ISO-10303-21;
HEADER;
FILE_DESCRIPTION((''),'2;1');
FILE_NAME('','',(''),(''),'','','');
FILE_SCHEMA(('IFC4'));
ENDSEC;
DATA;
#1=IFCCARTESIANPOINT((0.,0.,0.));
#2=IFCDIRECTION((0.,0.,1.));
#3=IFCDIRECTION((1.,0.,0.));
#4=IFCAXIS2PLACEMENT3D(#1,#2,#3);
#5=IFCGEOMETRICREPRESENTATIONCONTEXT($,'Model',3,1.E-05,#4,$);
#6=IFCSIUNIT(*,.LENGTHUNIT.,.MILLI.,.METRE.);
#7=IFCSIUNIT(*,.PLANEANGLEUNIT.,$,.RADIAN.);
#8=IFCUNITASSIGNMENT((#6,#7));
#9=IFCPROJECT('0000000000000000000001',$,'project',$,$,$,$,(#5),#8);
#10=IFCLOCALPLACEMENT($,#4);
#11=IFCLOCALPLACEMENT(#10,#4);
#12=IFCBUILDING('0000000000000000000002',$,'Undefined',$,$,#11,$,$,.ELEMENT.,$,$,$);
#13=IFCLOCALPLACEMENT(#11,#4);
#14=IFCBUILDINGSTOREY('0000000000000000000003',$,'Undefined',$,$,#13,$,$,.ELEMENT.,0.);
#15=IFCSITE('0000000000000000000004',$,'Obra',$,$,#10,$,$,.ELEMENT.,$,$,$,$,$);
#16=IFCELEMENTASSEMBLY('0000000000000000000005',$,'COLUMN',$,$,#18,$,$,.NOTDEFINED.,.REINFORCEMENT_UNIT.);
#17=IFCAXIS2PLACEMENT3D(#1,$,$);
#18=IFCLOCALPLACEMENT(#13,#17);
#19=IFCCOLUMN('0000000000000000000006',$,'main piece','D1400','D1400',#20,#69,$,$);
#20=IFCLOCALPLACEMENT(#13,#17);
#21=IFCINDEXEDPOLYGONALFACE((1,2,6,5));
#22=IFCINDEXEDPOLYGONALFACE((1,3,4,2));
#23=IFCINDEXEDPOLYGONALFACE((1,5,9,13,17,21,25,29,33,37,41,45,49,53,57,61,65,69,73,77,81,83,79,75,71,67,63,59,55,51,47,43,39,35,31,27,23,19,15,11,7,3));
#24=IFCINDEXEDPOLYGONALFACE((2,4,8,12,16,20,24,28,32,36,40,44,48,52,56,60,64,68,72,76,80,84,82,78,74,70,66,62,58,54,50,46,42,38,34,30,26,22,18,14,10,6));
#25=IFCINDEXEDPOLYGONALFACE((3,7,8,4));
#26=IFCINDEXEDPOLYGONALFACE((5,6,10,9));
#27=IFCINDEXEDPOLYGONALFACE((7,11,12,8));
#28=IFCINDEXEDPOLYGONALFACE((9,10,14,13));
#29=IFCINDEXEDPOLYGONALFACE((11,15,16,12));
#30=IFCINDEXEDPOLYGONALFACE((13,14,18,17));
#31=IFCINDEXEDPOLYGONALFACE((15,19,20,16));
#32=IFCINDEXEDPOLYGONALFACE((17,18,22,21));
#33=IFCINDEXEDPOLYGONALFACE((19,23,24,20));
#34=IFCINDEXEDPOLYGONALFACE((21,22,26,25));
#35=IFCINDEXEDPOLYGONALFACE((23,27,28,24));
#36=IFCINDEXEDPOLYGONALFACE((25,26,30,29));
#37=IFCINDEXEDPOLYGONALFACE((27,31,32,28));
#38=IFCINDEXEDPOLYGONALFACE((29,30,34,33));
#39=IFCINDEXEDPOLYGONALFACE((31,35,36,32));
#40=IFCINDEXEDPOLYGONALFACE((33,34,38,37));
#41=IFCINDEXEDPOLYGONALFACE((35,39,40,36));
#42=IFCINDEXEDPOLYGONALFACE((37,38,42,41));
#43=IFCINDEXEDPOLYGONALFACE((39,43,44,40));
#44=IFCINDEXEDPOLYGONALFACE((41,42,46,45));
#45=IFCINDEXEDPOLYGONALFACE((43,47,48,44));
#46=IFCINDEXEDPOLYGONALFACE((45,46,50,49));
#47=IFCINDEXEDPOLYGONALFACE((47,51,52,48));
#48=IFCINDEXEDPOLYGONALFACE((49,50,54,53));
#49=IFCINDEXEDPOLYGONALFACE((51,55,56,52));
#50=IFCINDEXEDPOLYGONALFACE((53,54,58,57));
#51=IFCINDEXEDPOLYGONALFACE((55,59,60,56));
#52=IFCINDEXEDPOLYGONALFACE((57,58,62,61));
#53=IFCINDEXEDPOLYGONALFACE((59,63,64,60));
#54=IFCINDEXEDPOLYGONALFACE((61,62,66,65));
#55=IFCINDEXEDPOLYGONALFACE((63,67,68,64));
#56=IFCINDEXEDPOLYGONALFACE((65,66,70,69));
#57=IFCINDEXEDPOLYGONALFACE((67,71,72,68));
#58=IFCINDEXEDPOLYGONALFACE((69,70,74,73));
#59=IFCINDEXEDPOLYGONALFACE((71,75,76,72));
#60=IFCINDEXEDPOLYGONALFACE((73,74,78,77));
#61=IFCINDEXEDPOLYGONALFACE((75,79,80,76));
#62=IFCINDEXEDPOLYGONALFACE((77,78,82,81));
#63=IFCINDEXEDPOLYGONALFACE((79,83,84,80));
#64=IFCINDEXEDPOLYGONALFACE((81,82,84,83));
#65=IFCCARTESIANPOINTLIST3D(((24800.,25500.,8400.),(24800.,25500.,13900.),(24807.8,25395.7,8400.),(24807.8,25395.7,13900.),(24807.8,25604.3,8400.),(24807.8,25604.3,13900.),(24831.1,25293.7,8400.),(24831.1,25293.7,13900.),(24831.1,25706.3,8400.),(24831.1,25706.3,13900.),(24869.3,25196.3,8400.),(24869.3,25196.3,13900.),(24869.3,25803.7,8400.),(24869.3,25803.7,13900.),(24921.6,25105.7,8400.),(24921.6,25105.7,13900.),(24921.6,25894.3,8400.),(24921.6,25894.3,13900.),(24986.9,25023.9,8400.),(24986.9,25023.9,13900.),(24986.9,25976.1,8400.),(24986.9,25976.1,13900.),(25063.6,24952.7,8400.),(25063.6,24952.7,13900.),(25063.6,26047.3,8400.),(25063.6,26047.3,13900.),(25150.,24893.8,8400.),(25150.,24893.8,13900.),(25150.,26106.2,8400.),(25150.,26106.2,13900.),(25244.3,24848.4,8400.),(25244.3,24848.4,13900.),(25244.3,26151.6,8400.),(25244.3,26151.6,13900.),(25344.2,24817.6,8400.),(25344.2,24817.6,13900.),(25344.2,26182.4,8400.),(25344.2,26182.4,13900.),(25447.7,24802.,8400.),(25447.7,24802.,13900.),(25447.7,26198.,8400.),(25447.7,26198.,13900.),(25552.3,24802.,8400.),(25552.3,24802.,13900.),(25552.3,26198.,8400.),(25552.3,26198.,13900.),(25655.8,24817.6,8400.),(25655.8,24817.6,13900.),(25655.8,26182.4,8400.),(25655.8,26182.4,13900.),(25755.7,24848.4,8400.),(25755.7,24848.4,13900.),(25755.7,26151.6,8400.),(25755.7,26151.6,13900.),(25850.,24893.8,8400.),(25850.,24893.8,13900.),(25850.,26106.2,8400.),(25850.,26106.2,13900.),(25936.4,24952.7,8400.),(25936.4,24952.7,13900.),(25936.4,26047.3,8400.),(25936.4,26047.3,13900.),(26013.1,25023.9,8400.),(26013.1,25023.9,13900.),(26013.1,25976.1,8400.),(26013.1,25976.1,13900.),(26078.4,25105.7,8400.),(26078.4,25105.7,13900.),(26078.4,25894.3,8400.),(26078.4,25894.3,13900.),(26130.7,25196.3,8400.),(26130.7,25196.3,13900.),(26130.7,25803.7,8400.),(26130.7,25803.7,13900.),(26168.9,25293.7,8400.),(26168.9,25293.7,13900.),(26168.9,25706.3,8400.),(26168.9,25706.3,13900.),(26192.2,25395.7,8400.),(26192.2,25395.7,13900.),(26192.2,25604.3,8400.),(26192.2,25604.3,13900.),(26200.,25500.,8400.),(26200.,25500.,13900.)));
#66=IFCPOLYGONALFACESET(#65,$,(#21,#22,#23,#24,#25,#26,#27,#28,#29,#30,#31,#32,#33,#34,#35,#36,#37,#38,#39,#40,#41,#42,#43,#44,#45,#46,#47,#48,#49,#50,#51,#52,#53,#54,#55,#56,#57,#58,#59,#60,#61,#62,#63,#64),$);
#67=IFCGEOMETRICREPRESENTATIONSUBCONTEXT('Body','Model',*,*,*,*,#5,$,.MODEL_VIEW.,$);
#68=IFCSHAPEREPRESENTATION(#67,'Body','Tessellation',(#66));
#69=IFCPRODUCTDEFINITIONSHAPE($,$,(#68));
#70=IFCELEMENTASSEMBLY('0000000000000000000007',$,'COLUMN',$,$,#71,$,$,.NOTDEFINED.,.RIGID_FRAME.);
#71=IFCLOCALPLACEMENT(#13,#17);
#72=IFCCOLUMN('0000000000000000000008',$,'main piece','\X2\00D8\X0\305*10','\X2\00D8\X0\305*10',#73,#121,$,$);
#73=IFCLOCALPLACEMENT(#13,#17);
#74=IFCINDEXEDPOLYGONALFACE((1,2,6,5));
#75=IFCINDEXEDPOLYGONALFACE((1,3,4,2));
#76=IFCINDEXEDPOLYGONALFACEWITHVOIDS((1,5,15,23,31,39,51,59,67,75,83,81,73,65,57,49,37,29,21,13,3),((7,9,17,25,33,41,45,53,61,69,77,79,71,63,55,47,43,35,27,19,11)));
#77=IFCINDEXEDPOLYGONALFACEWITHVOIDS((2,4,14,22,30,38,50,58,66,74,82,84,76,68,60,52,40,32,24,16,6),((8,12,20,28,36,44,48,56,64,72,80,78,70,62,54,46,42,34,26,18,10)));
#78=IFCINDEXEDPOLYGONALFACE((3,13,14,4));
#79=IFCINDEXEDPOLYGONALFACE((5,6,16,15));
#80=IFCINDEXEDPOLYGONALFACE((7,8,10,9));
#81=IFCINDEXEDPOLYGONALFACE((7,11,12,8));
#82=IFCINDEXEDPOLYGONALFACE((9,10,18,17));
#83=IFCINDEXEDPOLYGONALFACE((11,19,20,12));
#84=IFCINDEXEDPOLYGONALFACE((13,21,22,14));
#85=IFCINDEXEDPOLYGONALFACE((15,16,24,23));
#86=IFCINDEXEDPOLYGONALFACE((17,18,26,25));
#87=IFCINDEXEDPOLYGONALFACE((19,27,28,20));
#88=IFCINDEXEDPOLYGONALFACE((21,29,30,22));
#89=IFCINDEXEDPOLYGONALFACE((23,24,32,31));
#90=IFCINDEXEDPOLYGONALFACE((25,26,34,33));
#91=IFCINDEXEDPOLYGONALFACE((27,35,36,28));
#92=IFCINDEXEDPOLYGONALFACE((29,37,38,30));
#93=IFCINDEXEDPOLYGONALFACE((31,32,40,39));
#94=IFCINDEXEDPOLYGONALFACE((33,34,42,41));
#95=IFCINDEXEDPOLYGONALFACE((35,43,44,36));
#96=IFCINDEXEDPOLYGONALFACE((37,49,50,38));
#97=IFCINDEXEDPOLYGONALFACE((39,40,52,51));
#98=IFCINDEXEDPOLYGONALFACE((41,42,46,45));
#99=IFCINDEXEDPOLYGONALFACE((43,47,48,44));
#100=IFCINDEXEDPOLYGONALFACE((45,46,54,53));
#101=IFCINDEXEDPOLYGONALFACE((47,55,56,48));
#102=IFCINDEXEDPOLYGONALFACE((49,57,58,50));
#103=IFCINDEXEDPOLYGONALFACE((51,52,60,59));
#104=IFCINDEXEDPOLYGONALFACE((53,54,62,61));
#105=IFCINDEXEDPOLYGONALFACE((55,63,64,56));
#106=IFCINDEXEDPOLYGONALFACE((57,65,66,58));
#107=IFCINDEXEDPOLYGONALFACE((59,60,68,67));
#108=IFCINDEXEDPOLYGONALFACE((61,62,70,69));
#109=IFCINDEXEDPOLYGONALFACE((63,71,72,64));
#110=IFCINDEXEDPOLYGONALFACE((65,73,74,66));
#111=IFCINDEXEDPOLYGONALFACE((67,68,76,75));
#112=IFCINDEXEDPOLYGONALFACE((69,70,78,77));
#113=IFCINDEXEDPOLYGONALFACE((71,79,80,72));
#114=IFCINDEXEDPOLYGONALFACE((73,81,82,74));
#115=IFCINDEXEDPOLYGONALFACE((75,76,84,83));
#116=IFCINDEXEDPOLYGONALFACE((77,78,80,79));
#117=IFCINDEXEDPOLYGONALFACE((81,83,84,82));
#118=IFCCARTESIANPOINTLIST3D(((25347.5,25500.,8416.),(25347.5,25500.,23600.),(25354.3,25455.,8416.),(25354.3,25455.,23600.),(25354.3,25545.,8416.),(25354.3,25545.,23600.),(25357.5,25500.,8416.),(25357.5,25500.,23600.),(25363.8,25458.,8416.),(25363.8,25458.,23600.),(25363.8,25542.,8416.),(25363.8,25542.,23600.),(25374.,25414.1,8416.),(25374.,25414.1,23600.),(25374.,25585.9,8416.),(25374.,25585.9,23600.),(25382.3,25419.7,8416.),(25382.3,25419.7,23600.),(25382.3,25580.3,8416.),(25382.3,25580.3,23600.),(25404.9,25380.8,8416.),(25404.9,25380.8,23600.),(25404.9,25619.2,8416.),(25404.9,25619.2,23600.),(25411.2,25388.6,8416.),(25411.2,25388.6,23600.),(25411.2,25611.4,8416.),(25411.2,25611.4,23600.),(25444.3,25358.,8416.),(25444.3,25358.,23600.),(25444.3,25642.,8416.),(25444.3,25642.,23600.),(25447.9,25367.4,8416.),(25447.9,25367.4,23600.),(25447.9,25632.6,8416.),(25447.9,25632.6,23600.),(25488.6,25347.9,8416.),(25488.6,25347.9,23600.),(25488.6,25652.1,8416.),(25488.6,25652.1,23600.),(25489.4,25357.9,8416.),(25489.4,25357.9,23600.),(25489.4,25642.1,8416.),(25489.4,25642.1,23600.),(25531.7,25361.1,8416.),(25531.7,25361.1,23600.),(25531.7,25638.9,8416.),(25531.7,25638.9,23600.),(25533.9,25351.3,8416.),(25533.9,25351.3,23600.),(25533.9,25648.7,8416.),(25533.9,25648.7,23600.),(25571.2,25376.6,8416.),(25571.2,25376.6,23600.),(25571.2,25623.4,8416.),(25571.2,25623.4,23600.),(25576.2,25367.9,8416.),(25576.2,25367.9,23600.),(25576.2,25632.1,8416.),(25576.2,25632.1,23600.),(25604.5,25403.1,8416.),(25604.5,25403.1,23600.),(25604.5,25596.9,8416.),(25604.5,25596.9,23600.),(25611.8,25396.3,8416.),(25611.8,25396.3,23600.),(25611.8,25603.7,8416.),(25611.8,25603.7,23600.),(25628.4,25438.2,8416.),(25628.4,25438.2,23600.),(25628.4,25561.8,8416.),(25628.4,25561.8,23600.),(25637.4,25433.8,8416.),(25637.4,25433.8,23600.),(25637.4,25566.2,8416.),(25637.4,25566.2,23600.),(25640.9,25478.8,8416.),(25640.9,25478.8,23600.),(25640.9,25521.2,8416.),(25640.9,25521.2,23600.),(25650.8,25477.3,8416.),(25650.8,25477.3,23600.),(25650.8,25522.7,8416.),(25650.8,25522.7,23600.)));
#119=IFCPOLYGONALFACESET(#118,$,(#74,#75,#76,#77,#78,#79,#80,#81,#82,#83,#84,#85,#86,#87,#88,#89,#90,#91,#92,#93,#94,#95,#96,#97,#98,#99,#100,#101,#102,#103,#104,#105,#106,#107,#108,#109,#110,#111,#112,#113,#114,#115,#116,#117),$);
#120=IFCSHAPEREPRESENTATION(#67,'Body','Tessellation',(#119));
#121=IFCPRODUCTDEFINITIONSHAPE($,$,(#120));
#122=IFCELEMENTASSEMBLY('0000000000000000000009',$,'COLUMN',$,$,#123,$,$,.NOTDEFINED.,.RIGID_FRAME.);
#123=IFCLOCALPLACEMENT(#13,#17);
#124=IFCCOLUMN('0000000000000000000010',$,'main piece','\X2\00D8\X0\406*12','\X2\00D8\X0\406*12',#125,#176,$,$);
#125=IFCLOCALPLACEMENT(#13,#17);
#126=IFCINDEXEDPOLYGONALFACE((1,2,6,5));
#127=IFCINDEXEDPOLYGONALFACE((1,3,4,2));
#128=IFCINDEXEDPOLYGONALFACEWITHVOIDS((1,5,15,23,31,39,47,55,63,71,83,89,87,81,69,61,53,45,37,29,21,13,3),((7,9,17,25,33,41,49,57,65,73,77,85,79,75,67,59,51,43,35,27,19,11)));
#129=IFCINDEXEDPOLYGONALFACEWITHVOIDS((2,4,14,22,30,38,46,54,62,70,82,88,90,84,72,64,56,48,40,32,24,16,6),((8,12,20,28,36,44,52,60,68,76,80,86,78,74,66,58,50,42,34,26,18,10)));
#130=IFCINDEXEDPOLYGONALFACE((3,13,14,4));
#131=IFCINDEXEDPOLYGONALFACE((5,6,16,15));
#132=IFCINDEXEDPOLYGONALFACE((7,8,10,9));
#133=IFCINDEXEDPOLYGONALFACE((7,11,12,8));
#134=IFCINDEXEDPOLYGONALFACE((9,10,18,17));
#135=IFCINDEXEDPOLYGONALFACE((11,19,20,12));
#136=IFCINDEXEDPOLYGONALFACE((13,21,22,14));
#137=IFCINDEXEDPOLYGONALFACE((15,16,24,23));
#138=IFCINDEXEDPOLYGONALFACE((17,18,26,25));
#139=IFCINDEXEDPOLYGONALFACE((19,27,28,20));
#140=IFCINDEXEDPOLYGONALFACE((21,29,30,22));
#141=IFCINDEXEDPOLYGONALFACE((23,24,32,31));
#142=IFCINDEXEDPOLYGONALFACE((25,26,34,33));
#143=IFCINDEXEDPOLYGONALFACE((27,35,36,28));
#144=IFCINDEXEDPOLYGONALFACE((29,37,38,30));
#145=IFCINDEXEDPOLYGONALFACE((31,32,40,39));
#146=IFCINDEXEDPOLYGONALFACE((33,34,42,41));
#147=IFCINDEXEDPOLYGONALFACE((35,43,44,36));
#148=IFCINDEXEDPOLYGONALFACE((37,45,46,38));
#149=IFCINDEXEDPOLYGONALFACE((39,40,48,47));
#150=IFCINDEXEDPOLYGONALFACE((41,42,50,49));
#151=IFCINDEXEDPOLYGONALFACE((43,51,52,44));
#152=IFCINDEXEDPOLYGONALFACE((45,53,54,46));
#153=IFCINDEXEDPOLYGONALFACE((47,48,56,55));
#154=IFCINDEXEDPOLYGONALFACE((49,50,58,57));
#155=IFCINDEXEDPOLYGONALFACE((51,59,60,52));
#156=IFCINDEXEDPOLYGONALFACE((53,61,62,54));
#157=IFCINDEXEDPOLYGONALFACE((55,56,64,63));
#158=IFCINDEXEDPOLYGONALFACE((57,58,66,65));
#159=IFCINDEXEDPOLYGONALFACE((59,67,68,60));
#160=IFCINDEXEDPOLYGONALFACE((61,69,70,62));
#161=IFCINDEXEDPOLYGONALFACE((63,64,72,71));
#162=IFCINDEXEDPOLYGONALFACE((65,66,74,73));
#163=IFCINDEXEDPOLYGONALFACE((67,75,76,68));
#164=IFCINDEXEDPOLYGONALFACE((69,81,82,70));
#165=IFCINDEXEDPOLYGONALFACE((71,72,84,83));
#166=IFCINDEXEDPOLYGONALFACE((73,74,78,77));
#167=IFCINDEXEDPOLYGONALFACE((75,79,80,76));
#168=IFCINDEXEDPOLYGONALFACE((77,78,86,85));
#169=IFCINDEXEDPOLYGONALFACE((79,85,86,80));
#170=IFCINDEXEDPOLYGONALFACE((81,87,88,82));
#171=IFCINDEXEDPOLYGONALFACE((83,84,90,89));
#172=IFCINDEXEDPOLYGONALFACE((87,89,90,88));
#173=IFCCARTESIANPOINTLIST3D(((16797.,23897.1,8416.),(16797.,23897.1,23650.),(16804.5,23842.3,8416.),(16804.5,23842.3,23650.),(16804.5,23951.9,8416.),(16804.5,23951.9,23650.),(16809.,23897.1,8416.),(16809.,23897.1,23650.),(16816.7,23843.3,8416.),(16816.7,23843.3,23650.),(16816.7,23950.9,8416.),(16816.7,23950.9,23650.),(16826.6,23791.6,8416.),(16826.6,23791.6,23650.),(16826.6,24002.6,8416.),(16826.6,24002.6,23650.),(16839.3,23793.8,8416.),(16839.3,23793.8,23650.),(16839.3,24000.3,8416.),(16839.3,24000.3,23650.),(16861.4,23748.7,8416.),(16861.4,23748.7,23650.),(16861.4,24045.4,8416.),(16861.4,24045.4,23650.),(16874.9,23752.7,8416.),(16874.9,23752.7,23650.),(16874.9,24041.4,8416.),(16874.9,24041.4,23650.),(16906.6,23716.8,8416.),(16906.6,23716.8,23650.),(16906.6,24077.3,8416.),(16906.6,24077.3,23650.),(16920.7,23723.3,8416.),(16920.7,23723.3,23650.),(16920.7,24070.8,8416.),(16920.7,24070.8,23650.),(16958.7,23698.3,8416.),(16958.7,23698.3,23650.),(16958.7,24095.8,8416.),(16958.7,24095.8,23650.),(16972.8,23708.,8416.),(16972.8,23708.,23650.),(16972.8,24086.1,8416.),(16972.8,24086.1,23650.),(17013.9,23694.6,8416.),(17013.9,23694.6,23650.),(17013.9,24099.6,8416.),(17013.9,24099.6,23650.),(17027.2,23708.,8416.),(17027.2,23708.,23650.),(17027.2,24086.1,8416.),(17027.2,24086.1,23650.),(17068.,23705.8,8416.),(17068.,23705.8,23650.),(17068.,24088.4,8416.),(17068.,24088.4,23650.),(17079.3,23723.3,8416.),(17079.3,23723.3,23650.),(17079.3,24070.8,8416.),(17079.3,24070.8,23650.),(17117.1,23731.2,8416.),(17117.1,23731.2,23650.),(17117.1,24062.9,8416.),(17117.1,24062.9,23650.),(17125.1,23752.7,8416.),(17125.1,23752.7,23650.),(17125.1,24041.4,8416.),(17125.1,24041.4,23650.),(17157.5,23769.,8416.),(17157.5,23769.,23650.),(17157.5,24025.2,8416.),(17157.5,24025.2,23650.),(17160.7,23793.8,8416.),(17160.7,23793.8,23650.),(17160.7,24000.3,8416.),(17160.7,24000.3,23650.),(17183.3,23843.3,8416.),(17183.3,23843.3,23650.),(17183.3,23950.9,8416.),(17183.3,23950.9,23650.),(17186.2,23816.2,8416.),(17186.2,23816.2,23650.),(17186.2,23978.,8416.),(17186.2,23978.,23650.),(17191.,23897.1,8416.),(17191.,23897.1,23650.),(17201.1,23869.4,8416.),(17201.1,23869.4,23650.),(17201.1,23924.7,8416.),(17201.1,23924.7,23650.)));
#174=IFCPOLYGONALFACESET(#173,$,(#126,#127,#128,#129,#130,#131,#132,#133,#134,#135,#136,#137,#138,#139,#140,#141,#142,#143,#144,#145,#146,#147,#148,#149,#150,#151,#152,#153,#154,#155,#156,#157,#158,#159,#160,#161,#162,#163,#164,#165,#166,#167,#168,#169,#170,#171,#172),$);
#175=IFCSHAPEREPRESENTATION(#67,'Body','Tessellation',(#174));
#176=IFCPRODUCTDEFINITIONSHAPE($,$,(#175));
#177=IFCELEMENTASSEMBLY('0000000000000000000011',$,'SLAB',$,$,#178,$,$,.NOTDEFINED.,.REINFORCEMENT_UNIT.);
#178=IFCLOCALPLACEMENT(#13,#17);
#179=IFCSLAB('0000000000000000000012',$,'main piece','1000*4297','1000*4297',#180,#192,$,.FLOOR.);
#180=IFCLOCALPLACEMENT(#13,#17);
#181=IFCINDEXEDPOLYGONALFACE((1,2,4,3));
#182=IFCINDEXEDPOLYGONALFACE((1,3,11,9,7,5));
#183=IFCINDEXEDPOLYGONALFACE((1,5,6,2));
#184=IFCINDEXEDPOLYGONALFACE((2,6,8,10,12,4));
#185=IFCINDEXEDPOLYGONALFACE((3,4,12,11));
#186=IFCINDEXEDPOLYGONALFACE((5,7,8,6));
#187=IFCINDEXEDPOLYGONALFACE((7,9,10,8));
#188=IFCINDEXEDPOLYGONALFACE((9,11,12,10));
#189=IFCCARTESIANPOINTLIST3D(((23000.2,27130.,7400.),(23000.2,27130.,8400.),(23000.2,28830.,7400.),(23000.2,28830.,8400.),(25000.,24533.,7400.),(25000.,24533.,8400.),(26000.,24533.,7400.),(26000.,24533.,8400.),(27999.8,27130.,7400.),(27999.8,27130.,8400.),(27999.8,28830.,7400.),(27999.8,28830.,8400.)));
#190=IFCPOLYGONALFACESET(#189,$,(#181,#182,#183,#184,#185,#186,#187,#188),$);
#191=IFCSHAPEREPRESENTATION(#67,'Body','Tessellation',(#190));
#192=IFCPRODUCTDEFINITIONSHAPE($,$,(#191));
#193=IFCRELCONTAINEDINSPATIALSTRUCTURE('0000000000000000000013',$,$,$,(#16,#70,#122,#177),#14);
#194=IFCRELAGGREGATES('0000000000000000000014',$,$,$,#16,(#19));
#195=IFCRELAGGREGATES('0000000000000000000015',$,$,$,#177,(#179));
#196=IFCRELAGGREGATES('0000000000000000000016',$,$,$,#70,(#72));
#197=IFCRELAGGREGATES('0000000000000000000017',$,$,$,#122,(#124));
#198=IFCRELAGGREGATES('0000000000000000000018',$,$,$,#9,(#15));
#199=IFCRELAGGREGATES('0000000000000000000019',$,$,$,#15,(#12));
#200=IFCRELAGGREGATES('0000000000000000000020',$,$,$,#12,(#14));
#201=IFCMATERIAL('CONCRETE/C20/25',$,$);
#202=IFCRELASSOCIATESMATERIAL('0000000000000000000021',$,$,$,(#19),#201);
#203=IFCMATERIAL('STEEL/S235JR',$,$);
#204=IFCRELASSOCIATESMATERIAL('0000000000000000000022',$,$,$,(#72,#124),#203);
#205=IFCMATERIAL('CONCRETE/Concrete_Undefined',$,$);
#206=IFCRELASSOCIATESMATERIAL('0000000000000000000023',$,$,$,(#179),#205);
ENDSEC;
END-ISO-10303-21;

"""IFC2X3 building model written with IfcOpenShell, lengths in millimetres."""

from ifc_helpers import new_model, si_unit, frame, origin_with_axes, origin_2d_with_axis, place, context, subcontext, project, spatial, polyline, circle, hollow_circle, outline, extrude, clip, halfspace, material, element, aggregate, save


model = new_model("IFC2X3")

# Units and contexts
model_context = context("Model", 3, precision=1e-05, world=origin_with_axes())
body_context = subcontext(model_context, "Body", "Model", "MODEL_VIEW")
ifc_project = project(units=[si_unit("LENGTHUNIT", "METRE", prefix="MILLI"), si_unit("PLANEANGLEUNIT", "RADIAN")], contexts=[model_context])

# Site, building, storey
site_placement = place(None, origin_with_axes())
site = spatial("IfcSite", under=ifc_project, at=site_placement, Name="Obra", CompositionType="ELEMENT")
building_placement = place(site_placement, origin_with_axes())
building = spatial("IfcBuilding", under=site, at=building_placement, Name="Undefined", CompositionType="ELEMENT")
storey_placement = place(building_placement, origin_with_axes())
storey = spatial("IfcBuildingStorey", under=building, at=storey_placement, Name="Undefined", CompositionType="ELEMENT", Elevation=0.0)

# Element assemblies, columns
assembly_1_placement = place(storey_placement, origin_with_axes())
assembly_1 = element("IfcElementAssembly", 1, at=assembly_1_placement, inside=storey, Name="COLUMN", AssemblyPlace="NOTDEFINED", PredefinedType="REINFORCEMENT_UNIT")
ifc_material_1 = material(Name="CONCRETE/C20/25")
column_1_placement = place(assembly_1_placement, frame((25500.0, 25500.0, 8400.0), z_axis=(0.0, 0.0, 1.0), x_axis=(0.0, 1.0, 0.0)))
column_1 = element("IfcColumn", 2, at=column_1_placement, material=ifc_material_1, Name="main piece", Description="D1400", ObjectType="D1400", context=body_context, shape_type="SweptSolid", body=[
    extrude(circle(Radius=700.0, at=origin_2d_with_axis()), frame((0.0, 0.0, 5500.0), z_axis=(0.0, 0.0, -1.0), x_axis=(0.0, 1.0, 0.0)), (0.0, 0.0, 1.0), 5500.0),
])
aggregate(assembly_1, [column_1])
assembly_2_placement = place(storey_placement, origin_with_axes())
assembly_2 = element("IfcElementAssembly", 3, at=assembly_2_placement, inside=storey, Name="COLUMN", AssemblyPlace="NOTDEFINED", PredefinedType="RIGID_FRAME")
ifc_material_2 = material(Name="STEEL/S235JR")
column_2_placement = place(assembly_2_placement, frame((25500.0, 25500.0, 8400.0), z_axis=(0.0, 0.0, 1.0), x_axis=(0.0, 1.0, 0.0)))
column_2 = element("IfcColumn", 4, at=column_2_placement, material=ifc_material_2, Name="main piece", Description="Ø305*10", ObjectType="Ø305*10", context=body_context, shape_type="Clipping", body=[
    clip(extrude(hollow_circle(Radius=152.5, WallThickness=10.0, at=origin_2d_with_axis()), frame((0.0, 0.0, 15200.0), z_axis=(0.0, 0.0, -1.0), x_axis=(0.0, 1.0, 0.0)), (0.0, 0.0, 1.0), 15184.0), halfspace(frame((-152.5, 0.0, 16.0), z_axis=(0.0, 0.0, 1.0), x_axis=(0.0, 1.0, 0.0)), True)),
])
assembly_3_placement = place(storey_placement, origin_with_axes())
assembly_3 = element("IfcElementAssembly", 5, at=assembly_3_placement, inside=storey, Name="COLUMN", AssemblyPlace="NOTDEFINED", PredefinedType="RIGID_FRAME")
column_3_placement = place(assembly_3_placement, frame((17000.0, 23897.1, 8400.0), z_axis=(0.0, 0.0, 1.0), x_axis=(0.0, 1.0, 0.0)))
column_3 = element("IfcColumn", 6, at=column_3_placement, material=ifc_material_2, Name="main piece", Description="Ø406*12", ObjectType="Ø406*12", context=body_context, shape_type="Clipping", body=[
    clip(extrude(hollow_circle(Radius=203.0, WallThickness=12.0, at=origin_2d_with_axis()), frame((0.0, 0.0, 15250.0), z_axis=(0.0, 0.0, -1.0), x_axis=(0.0, 1.0, 0.0)), (0.0, 0.0, 1.0), 15234.0), halfspace(frame((-203.0, 0.0, 16.0), z_axis=(0.0, 0.0, 1.0), x_axis=(0.0, 1.0, 0.0)), True)),
])

# Element assembly, slab
assembly_4_placement = place(storey_placement, origin_with_axes())
assembly_4 = element("IfcElementAssembly", 7, at=assembly_4_placement, inside=storey, Name="SLAB", AssemblyPlace="NOTDEFINED", PredefinedType="REINFORCEMENT_UNIT")
ifc_material_3 = material(Name="CONCRETE/Concrete_Undefined")
slab_placement = place(assembly_4_placement, frame((23000.2, 27130.0, 7900.0), z_axis=(0.0, 0.0, -1.0), x_axis=(0.0, 1.0, 0.0)))
slab = element("IfcSlab", 8, at=slab_placement, material=ifc_material_3, Name="main piece", Description="1000*4297", ObjectType="1000*4297", PredefinedType="FLOOR", context=body_context, shape_type="SweptSolid", body=[
    extrude(outline(polyline([(0.0, 0.0), (1700.0, 0.0), (1700.0, 4999.6), (0.0, 4999.6), (-2597.0, 2999.8), (-2597.0, 1999.8), (0.0, 0.0)])), frame((0.0, 0.0, -500.0), z_axis=(0.0, 0.0, 1.0), x_axis=(1.0, 0.0, 0.0)), (0.0, 0.0, 1.0), 1000.0),
])
aggregate(assembly_4, [slab])

aggregate(assembly_2, [column_2])
aggregate(assembly_3, [column_3])

save(model, "model.ifc")
